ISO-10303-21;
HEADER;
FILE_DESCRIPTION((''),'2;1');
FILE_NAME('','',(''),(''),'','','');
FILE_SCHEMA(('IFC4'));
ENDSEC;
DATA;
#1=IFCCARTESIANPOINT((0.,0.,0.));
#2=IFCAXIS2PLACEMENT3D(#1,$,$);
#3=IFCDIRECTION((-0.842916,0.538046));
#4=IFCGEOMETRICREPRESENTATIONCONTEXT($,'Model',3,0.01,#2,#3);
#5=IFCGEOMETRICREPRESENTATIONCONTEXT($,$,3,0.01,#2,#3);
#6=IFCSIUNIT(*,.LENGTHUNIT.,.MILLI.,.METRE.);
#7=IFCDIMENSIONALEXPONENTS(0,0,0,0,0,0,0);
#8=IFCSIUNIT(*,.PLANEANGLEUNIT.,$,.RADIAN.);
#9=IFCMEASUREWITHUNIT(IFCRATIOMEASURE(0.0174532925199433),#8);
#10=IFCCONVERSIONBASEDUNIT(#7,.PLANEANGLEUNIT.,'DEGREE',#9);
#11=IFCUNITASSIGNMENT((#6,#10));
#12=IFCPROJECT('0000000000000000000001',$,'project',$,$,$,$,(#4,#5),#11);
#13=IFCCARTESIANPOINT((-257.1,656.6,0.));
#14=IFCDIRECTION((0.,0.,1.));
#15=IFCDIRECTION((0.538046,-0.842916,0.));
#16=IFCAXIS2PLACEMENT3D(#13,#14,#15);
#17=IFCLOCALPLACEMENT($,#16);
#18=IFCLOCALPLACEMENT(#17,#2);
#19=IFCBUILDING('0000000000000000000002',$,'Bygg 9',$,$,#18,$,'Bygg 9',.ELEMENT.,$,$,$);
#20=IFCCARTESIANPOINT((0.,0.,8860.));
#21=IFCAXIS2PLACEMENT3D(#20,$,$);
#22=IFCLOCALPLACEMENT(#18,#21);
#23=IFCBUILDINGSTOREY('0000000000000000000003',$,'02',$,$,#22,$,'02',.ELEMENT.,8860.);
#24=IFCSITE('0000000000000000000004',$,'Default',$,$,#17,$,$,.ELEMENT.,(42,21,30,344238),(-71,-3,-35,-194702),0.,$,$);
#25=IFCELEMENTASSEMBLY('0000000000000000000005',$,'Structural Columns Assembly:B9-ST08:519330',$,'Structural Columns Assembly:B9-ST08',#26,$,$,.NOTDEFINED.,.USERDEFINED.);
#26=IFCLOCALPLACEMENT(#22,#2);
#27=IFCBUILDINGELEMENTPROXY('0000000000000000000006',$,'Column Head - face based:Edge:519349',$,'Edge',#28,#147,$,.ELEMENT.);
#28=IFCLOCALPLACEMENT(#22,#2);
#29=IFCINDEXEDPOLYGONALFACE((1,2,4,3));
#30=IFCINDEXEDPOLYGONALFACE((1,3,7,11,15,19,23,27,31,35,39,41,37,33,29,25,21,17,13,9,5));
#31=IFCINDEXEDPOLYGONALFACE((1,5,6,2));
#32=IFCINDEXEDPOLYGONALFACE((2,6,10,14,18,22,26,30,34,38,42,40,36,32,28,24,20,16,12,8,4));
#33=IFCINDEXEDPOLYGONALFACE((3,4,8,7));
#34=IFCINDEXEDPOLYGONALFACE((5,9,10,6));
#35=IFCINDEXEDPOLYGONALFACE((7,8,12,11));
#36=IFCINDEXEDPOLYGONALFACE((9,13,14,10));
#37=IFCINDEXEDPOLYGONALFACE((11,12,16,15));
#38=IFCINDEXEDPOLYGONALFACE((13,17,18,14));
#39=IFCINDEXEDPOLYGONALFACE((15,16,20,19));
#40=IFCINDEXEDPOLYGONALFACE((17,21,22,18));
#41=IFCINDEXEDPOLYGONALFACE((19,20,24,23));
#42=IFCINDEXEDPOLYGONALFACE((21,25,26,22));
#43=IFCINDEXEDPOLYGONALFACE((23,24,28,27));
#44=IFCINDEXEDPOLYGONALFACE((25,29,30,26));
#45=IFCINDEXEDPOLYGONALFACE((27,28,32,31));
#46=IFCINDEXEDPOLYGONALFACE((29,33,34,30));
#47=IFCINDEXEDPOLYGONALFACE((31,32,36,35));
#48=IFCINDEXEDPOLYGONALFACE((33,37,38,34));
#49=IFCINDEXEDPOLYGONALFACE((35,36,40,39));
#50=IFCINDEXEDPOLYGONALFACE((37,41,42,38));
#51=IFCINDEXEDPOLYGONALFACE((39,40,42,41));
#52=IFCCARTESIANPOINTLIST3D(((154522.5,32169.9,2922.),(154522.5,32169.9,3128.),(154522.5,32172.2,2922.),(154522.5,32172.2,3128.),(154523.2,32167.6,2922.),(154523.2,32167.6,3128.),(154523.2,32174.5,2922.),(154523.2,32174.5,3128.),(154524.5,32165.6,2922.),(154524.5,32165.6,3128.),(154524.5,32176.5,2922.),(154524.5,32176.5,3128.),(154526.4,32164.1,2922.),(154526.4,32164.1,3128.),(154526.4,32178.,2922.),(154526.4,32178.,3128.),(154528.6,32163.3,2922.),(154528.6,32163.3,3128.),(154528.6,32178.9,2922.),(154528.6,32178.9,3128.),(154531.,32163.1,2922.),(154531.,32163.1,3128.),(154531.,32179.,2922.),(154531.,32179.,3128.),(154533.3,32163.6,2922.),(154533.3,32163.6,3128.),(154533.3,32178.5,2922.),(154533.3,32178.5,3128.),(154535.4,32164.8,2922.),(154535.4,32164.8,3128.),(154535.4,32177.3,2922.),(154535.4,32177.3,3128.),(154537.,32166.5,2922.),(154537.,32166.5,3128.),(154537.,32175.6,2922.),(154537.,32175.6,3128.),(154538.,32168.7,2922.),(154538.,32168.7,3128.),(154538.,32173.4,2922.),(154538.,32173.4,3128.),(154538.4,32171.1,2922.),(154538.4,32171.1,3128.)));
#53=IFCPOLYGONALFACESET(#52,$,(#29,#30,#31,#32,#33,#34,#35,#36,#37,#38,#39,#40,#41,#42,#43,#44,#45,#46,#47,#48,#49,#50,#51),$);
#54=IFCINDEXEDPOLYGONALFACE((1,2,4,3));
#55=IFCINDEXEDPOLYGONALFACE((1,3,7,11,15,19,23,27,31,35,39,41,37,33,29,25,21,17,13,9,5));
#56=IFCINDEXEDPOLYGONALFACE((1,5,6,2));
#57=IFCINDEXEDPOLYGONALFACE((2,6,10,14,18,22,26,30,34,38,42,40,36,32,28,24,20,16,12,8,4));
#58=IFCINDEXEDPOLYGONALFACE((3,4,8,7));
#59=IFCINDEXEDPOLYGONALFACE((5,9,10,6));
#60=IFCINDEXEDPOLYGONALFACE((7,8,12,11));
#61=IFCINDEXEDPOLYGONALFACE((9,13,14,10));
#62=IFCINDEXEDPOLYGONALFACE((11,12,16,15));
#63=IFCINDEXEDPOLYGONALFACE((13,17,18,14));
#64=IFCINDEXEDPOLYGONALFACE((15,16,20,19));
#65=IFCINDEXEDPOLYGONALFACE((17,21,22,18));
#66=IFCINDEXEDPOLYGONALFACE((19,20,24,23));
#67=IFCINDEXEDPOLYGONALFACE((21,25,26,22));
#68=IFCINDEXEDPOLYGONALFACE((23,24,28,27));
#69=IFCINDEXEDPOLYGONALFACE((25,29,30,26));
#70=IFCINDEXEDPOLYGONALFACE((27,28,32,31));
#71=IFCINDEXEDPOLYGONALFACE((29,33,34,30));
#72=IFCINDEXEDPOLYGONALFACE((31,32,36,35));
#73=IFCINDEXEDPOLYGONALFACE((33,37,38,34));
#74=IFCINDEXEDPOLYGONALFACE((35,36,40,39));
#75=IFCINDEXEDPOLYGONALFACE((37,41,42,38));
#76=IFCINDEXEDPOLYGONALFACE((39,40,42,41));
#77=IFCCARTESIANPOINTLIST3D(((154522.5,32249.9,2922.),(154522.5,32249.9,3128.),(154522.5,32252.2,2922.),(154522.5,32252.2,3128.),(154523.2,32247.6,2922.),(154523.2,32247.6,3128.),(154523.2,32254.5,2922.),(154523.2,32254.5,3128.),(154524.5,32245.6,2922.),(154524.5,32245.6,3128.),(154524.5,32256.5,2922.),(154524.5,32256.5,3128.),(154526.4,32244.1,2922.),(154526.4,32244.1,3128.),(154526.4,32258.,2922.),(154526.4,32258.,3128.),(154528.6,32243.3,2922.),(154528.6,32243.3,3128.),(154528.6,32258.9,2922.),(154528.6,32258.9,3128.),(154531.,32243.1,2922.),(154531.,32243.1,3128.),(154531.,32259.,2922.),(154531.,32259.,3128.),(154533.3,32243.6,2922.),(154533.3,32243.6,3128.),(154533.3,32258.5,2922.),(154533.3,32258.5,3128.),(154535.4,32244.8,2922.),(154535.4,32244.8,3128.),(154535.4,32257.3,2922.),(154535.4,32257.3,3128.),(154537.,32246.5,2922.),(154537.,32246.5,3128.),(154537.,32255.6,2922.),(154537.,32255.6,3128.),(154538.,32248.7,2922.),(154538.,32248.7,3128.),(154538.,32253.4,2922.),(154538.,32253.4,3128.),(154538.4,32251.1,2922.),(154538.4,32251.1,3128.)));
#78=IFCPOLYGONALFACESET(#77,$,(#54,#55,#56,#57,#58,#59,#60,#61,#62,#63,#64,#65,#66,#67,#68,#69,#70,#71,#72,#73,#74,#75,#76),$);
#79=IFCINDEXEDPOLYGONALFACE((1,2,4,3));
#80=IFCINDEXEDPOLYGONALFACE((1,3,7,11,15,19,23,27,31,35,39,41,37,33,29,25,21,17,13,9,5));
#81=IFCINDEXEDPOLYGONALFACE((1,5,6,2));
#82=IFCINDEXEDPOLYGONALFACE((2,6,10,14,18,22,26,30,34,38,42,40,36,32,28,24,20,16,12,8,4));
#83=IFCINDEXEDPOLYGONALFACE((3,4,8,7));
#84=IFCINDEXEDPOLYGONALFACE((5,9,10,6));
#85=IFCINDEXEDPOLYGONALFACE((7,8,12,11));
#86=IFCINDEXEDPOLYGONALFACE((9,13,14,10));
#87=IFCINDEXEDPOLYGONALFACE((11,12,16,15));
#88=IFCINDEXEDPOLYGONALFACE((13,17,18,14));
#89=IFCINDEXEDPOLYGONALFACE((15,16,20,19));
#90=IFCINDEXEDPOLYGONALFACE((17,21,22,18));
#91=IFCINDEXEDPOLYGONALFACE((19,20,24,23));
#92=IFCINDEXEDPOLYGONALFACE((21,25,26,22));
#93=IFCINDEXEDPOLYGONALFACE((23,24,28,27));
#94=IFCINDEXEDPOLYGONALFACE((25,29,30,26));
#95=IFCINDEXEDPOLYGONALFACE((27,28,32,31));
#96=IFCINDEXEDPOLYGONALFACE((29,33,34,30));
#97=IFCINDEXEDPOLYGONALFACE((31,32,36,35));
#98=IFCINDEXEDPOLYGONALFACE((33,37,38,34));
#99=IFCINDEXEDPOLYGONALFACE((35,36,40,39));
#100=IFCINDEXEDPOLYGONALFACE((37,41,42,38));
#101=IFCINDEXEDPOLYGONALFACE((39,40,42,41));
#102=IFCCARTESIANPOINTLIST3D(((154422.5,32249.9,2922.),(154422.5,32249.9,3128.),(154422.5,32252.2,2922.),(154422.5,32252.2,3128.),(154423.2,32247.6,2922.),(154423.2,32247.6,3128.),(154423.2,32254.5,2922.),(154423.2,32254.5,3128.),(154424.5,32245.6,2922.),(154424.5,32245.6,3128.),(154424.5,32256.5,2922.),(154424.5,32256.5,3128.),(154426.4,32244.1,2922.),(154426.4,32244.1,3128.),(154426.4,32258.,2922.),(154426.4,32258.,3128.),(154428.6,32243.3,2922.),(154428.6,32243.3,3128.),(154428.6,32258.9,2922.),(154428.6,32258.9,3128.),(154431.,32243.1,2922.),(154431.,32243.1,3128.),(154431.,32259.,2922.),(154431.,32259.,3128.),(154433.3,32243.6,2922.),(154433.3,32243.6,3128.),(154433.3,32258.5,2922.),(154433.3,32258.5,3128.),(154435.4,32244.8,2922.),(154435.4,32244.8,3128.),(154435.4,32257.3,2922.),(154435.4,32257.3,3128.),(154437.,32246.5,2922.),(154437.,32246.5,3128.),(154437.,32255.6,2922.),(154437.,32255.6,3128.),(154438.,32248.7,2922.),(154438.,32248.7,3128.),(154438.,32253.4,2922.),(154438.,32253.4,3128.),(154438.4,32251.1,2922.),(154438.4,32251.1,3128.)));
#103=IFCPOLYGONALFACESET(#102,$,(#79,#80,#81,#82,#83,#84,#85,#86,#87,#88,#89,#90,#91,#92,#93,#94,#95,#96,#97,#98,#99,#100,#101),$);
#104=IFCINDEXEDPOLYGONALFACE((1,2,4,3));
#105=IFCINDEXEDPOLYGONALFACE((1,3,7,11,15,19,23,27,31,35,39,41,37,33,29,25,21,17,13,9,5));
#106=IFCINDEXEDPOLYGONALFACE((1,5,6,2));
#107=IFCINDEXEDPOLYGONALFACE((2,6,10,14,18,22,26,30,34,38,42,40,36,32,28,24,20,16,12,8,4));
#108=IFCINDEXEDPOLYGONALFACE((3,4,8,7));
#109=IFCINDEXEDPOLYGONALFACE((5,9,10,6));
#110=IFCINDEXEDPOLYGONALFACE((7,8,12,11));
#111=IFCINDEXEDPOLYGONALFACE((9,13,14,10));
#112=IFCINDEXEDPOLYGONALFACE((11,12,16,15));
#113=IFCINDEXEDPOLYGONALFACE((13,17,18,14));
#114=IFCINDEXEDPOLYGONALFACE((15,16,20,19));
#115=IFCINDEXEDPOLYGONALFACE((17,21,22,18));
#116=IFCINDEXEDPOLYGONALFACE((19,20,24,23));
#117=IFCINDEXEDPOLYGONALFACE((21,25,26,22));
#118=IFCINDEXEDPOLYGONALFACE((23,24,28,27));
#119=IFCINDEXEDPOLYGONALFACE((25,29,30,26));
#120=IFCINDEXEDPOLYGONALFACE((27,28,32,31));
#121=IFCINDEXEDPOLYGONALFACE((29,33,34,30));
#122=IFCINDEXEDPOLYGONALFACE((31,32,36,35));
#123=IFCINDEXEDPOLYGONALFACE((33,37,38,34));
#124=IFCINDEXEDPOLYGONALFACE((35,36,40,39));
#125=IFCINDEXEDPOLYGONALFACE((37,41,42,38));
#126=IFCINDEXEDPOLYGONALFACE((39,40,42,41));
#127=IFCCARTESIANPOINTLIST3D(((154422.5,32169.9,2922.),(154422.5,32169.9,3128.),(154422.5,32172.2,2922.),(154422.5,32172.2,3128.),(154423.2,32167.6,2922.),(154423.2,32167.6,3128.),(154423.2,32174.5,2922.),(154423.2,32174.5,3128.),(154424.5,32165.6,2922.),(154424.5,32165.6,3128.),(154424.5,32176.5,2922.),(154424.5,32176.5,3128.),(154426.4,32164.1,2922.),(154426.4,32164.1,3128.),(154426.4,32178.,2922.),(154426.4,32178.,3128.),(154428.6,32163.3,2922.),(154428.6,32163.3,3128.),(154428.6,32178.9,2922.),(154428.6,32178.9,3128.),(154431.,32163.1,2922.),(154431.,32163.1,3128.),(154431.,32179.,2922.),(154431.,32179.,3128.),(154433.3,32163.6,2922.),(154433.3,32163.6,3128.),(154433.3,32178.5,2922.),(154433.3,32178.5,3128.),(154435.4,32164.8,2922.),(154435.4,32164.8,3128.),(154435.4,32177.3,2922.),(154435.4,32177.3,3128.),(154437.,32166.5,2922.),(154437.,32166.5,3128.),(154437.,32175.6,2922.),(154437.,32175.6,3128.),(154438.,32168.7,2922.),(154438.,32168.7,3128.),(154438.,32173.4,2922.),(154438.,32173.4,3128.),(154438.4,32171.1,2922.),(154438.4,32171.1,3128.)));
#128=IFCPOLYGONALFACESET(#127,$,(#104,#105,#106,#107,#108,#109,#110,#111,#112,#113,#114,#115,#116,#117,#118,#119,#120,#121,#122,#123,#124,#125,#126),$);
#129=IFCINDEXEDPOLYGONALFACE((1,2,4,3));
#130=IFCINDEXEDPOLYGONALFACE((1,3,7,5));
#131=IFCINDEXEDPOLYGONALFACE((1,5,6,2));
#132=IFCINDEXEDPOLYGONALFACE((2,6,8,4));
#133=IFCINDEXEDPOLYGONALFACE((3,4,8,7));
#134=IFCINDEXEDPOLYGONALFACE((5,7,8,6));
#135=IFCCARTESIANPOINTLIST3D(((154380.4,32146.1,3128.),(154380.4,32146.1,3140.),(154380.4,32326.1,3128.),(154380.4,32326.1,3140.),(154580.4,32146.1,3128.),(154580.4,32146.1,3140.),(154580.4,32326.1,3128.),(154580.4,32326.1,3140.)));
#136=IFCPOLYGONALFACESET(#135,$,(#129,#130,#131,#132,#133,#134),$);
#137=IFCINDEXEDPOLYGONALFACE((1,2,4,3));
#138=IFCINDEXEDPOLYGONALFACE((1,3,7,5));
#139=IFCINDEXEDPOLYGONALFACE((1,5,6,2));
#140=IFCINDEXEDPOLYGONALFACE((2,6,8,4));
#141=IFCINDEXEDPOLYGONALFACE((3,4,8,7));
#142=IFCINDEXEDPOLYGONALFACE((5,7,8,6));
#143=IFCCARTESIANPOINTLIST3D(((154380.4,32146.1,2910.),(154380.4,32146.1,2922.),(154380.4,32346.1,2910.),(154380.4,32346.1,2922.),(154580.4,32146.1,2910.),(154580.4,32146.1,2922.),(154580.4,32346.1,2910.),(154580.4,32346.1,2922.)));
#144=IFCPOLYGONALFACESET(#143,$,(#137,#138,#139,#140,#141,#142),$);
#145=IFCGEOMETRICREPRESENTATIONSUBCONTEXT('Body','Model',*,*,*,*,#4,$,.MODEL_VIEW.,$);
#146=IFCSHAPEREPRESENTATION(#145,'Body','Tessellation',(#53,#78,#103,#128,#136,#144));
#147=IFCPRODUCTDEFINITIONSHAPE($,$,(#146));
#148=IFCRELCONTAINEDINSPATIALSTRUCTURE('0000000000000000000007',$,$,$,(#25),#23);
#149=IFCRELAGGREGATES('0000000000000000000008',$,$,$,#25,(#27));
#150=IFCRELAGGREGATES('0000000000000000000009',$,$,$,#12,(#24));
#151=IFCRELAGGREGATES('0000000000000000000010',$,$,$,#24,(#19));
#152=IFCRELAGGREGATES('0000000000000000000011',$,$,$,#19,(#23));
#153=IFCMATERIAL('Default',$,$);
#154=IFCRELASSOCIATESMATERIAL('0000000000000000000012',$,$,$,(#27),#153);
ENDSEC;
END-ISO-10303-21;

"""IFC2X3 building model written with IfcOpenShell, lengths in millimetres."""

from ifc_helpers import new_model, entity, si_unit, converted_unit, direction, frame, frame_2d, origin, origin_2d_with_axis, place, context, subcontext, project, spatial, rectangle, circle, extrude, source, transform, mapped, material, element, aggregate, save


model = new_model("IFC2X3")

# Units and contexts
model_context = context("Model", 3, precision=0.01, world=origin(), true_north=direction((-0.842916, 0.538046)))
context_of_model = context(None, 3, precision=0.01, world=origin(), true_north=direction((-0.842916, 0.538046)))
body_context = subcontext(model_context, "Body", "Model", "MODEL_VIEW")
ifc_project = project(units=[si_unit("LENGTHUNIT", "METRE", prefix="MILLI"), converted_unit("PLANEANGLEUNIT", "DEGREE", entity("IfcRatioMeasure", 0.0174532925199433), si_unit("PLANEANGLEUNIT", "RADIAN"), dimensions=[0, 0, 0, 0, 0, 0, 0])], contexts=[model_context, context_of_model])

# Site, building, storey
site_placement = place(None, frame((-257.1, 656.6, 0.0), z_axis=(0.0, 0.0, 1.0), x_axis=(0.538046, -0.842916, 0.0)))
site = spatial("IfcSite", under=ifc_project, at=site_placement, Name="Default", CompositionType="ELEMENT", RefLatitude=(42, 21, 30, 344238), RefLongitude=(-71, -3, -35, -194702), RefElevation=0.0)
building_placement = place(site_placement, origin())
building = spatial("IfcBuilding", under=site, at=building_placement, Name="Bygg 9", LongName="Bygg 9", CompositionType="ELEMENT")
storey_placement = place(building_placement, frame((0.0, 0.0, 8860.0)))
storey = spatial("IfcBuildingStorey", under=building, at=storey_placement, Name="02", LongName="02", CompositionType="ELEMENT", Elevation=8860.0)

# Shared definitions
ifc_material_1 = material(Name="Default")

# Element assembly, building element proxy
assembly_1_placement = place(storey_placement, origin())
assembly_1 = element("IfcElementAssembly", 1, at=assembly_1_placement, inside=storey, Name="Structural Columns Assembly:B9-ST08:519330", ObjectType="Structural Columns Assembly:B9-ST08", AssemblyPlace="NOTDEFINED", PredefinedType="USERDEFINED")
shared_shape_1 = source(origin(), body_context, "Body", "SweptSolid", [
    extrude(circle(Radius=8.0, at=frame_2d((0.0, 0.0), x_axis=(1.0, 0.0))), frame((50.0, -135.0, 12.0)), (0.0, 0.0, 1.0), 206.0),
    extrude(circle(Radius=8.0, at=frame_2d((0.0, 0.0), x_axis=(1.0, 0.0))), frame((50.0, -55.0, 12.0)), (0.0, 0.0, 1.0), 206.0),
    extrude(circle(Radius=8.0, at=frame_2d((0.0, 0.0), x_axis=(1.0, 0.0))), frame((-50.0, -55.0, 12.0)), (0.0, 0.0, 1.0), 206.0),
    extrude(circle(Radius=8.0, at=frame_2d((0.0, 0.0), x_axis=(1.0, 0.0))), frame((-50.0, -135.0, 12.0)), (0.0, 0.0, 1.0), 206.0),
    extrude(rectangle(XDim=200.0, YDim=180.0, at=origin_2d_with_axis()), frame((0.0, -70.0, 218.0), z_axis=(0.0, 0.0, 1.0), x_axis=(-1.0, 0.0, 0.0)), (0.0, 0.0, 1.0), 12.0),
    extrude(rectangle(XDim=200.0, YDim=200.0, at=origin_2d_with_axis()), frame((0.0, -60.0, 0.0), z_axis=(0.0, 0.0, 1.0), x_axis=(0.0, 1.0, 0.0)), (0.0, 0.0, 1.0), 12.0),
])
proxy_1_placement = place(assembly_1_placement, frame((154480.4, 32306.1, 2910.0)))
proxy_1 = element("IfcBuildingElementProxy", 2, at=proxy_1_placement, material=ifc_material_1, Name="Column Head - face based:Edge:519349", ObjectType="Edge", CompositionType="ELEMENT", context=body_context, shape_type="MappedRepresentation", body=[
    mapped(shared_shape_1, transform((0.0, 0.0, 0.0), scale=1.0)),
])
aggregate(assembly_1, [proxy_1])

save(model, "model.ifc")
